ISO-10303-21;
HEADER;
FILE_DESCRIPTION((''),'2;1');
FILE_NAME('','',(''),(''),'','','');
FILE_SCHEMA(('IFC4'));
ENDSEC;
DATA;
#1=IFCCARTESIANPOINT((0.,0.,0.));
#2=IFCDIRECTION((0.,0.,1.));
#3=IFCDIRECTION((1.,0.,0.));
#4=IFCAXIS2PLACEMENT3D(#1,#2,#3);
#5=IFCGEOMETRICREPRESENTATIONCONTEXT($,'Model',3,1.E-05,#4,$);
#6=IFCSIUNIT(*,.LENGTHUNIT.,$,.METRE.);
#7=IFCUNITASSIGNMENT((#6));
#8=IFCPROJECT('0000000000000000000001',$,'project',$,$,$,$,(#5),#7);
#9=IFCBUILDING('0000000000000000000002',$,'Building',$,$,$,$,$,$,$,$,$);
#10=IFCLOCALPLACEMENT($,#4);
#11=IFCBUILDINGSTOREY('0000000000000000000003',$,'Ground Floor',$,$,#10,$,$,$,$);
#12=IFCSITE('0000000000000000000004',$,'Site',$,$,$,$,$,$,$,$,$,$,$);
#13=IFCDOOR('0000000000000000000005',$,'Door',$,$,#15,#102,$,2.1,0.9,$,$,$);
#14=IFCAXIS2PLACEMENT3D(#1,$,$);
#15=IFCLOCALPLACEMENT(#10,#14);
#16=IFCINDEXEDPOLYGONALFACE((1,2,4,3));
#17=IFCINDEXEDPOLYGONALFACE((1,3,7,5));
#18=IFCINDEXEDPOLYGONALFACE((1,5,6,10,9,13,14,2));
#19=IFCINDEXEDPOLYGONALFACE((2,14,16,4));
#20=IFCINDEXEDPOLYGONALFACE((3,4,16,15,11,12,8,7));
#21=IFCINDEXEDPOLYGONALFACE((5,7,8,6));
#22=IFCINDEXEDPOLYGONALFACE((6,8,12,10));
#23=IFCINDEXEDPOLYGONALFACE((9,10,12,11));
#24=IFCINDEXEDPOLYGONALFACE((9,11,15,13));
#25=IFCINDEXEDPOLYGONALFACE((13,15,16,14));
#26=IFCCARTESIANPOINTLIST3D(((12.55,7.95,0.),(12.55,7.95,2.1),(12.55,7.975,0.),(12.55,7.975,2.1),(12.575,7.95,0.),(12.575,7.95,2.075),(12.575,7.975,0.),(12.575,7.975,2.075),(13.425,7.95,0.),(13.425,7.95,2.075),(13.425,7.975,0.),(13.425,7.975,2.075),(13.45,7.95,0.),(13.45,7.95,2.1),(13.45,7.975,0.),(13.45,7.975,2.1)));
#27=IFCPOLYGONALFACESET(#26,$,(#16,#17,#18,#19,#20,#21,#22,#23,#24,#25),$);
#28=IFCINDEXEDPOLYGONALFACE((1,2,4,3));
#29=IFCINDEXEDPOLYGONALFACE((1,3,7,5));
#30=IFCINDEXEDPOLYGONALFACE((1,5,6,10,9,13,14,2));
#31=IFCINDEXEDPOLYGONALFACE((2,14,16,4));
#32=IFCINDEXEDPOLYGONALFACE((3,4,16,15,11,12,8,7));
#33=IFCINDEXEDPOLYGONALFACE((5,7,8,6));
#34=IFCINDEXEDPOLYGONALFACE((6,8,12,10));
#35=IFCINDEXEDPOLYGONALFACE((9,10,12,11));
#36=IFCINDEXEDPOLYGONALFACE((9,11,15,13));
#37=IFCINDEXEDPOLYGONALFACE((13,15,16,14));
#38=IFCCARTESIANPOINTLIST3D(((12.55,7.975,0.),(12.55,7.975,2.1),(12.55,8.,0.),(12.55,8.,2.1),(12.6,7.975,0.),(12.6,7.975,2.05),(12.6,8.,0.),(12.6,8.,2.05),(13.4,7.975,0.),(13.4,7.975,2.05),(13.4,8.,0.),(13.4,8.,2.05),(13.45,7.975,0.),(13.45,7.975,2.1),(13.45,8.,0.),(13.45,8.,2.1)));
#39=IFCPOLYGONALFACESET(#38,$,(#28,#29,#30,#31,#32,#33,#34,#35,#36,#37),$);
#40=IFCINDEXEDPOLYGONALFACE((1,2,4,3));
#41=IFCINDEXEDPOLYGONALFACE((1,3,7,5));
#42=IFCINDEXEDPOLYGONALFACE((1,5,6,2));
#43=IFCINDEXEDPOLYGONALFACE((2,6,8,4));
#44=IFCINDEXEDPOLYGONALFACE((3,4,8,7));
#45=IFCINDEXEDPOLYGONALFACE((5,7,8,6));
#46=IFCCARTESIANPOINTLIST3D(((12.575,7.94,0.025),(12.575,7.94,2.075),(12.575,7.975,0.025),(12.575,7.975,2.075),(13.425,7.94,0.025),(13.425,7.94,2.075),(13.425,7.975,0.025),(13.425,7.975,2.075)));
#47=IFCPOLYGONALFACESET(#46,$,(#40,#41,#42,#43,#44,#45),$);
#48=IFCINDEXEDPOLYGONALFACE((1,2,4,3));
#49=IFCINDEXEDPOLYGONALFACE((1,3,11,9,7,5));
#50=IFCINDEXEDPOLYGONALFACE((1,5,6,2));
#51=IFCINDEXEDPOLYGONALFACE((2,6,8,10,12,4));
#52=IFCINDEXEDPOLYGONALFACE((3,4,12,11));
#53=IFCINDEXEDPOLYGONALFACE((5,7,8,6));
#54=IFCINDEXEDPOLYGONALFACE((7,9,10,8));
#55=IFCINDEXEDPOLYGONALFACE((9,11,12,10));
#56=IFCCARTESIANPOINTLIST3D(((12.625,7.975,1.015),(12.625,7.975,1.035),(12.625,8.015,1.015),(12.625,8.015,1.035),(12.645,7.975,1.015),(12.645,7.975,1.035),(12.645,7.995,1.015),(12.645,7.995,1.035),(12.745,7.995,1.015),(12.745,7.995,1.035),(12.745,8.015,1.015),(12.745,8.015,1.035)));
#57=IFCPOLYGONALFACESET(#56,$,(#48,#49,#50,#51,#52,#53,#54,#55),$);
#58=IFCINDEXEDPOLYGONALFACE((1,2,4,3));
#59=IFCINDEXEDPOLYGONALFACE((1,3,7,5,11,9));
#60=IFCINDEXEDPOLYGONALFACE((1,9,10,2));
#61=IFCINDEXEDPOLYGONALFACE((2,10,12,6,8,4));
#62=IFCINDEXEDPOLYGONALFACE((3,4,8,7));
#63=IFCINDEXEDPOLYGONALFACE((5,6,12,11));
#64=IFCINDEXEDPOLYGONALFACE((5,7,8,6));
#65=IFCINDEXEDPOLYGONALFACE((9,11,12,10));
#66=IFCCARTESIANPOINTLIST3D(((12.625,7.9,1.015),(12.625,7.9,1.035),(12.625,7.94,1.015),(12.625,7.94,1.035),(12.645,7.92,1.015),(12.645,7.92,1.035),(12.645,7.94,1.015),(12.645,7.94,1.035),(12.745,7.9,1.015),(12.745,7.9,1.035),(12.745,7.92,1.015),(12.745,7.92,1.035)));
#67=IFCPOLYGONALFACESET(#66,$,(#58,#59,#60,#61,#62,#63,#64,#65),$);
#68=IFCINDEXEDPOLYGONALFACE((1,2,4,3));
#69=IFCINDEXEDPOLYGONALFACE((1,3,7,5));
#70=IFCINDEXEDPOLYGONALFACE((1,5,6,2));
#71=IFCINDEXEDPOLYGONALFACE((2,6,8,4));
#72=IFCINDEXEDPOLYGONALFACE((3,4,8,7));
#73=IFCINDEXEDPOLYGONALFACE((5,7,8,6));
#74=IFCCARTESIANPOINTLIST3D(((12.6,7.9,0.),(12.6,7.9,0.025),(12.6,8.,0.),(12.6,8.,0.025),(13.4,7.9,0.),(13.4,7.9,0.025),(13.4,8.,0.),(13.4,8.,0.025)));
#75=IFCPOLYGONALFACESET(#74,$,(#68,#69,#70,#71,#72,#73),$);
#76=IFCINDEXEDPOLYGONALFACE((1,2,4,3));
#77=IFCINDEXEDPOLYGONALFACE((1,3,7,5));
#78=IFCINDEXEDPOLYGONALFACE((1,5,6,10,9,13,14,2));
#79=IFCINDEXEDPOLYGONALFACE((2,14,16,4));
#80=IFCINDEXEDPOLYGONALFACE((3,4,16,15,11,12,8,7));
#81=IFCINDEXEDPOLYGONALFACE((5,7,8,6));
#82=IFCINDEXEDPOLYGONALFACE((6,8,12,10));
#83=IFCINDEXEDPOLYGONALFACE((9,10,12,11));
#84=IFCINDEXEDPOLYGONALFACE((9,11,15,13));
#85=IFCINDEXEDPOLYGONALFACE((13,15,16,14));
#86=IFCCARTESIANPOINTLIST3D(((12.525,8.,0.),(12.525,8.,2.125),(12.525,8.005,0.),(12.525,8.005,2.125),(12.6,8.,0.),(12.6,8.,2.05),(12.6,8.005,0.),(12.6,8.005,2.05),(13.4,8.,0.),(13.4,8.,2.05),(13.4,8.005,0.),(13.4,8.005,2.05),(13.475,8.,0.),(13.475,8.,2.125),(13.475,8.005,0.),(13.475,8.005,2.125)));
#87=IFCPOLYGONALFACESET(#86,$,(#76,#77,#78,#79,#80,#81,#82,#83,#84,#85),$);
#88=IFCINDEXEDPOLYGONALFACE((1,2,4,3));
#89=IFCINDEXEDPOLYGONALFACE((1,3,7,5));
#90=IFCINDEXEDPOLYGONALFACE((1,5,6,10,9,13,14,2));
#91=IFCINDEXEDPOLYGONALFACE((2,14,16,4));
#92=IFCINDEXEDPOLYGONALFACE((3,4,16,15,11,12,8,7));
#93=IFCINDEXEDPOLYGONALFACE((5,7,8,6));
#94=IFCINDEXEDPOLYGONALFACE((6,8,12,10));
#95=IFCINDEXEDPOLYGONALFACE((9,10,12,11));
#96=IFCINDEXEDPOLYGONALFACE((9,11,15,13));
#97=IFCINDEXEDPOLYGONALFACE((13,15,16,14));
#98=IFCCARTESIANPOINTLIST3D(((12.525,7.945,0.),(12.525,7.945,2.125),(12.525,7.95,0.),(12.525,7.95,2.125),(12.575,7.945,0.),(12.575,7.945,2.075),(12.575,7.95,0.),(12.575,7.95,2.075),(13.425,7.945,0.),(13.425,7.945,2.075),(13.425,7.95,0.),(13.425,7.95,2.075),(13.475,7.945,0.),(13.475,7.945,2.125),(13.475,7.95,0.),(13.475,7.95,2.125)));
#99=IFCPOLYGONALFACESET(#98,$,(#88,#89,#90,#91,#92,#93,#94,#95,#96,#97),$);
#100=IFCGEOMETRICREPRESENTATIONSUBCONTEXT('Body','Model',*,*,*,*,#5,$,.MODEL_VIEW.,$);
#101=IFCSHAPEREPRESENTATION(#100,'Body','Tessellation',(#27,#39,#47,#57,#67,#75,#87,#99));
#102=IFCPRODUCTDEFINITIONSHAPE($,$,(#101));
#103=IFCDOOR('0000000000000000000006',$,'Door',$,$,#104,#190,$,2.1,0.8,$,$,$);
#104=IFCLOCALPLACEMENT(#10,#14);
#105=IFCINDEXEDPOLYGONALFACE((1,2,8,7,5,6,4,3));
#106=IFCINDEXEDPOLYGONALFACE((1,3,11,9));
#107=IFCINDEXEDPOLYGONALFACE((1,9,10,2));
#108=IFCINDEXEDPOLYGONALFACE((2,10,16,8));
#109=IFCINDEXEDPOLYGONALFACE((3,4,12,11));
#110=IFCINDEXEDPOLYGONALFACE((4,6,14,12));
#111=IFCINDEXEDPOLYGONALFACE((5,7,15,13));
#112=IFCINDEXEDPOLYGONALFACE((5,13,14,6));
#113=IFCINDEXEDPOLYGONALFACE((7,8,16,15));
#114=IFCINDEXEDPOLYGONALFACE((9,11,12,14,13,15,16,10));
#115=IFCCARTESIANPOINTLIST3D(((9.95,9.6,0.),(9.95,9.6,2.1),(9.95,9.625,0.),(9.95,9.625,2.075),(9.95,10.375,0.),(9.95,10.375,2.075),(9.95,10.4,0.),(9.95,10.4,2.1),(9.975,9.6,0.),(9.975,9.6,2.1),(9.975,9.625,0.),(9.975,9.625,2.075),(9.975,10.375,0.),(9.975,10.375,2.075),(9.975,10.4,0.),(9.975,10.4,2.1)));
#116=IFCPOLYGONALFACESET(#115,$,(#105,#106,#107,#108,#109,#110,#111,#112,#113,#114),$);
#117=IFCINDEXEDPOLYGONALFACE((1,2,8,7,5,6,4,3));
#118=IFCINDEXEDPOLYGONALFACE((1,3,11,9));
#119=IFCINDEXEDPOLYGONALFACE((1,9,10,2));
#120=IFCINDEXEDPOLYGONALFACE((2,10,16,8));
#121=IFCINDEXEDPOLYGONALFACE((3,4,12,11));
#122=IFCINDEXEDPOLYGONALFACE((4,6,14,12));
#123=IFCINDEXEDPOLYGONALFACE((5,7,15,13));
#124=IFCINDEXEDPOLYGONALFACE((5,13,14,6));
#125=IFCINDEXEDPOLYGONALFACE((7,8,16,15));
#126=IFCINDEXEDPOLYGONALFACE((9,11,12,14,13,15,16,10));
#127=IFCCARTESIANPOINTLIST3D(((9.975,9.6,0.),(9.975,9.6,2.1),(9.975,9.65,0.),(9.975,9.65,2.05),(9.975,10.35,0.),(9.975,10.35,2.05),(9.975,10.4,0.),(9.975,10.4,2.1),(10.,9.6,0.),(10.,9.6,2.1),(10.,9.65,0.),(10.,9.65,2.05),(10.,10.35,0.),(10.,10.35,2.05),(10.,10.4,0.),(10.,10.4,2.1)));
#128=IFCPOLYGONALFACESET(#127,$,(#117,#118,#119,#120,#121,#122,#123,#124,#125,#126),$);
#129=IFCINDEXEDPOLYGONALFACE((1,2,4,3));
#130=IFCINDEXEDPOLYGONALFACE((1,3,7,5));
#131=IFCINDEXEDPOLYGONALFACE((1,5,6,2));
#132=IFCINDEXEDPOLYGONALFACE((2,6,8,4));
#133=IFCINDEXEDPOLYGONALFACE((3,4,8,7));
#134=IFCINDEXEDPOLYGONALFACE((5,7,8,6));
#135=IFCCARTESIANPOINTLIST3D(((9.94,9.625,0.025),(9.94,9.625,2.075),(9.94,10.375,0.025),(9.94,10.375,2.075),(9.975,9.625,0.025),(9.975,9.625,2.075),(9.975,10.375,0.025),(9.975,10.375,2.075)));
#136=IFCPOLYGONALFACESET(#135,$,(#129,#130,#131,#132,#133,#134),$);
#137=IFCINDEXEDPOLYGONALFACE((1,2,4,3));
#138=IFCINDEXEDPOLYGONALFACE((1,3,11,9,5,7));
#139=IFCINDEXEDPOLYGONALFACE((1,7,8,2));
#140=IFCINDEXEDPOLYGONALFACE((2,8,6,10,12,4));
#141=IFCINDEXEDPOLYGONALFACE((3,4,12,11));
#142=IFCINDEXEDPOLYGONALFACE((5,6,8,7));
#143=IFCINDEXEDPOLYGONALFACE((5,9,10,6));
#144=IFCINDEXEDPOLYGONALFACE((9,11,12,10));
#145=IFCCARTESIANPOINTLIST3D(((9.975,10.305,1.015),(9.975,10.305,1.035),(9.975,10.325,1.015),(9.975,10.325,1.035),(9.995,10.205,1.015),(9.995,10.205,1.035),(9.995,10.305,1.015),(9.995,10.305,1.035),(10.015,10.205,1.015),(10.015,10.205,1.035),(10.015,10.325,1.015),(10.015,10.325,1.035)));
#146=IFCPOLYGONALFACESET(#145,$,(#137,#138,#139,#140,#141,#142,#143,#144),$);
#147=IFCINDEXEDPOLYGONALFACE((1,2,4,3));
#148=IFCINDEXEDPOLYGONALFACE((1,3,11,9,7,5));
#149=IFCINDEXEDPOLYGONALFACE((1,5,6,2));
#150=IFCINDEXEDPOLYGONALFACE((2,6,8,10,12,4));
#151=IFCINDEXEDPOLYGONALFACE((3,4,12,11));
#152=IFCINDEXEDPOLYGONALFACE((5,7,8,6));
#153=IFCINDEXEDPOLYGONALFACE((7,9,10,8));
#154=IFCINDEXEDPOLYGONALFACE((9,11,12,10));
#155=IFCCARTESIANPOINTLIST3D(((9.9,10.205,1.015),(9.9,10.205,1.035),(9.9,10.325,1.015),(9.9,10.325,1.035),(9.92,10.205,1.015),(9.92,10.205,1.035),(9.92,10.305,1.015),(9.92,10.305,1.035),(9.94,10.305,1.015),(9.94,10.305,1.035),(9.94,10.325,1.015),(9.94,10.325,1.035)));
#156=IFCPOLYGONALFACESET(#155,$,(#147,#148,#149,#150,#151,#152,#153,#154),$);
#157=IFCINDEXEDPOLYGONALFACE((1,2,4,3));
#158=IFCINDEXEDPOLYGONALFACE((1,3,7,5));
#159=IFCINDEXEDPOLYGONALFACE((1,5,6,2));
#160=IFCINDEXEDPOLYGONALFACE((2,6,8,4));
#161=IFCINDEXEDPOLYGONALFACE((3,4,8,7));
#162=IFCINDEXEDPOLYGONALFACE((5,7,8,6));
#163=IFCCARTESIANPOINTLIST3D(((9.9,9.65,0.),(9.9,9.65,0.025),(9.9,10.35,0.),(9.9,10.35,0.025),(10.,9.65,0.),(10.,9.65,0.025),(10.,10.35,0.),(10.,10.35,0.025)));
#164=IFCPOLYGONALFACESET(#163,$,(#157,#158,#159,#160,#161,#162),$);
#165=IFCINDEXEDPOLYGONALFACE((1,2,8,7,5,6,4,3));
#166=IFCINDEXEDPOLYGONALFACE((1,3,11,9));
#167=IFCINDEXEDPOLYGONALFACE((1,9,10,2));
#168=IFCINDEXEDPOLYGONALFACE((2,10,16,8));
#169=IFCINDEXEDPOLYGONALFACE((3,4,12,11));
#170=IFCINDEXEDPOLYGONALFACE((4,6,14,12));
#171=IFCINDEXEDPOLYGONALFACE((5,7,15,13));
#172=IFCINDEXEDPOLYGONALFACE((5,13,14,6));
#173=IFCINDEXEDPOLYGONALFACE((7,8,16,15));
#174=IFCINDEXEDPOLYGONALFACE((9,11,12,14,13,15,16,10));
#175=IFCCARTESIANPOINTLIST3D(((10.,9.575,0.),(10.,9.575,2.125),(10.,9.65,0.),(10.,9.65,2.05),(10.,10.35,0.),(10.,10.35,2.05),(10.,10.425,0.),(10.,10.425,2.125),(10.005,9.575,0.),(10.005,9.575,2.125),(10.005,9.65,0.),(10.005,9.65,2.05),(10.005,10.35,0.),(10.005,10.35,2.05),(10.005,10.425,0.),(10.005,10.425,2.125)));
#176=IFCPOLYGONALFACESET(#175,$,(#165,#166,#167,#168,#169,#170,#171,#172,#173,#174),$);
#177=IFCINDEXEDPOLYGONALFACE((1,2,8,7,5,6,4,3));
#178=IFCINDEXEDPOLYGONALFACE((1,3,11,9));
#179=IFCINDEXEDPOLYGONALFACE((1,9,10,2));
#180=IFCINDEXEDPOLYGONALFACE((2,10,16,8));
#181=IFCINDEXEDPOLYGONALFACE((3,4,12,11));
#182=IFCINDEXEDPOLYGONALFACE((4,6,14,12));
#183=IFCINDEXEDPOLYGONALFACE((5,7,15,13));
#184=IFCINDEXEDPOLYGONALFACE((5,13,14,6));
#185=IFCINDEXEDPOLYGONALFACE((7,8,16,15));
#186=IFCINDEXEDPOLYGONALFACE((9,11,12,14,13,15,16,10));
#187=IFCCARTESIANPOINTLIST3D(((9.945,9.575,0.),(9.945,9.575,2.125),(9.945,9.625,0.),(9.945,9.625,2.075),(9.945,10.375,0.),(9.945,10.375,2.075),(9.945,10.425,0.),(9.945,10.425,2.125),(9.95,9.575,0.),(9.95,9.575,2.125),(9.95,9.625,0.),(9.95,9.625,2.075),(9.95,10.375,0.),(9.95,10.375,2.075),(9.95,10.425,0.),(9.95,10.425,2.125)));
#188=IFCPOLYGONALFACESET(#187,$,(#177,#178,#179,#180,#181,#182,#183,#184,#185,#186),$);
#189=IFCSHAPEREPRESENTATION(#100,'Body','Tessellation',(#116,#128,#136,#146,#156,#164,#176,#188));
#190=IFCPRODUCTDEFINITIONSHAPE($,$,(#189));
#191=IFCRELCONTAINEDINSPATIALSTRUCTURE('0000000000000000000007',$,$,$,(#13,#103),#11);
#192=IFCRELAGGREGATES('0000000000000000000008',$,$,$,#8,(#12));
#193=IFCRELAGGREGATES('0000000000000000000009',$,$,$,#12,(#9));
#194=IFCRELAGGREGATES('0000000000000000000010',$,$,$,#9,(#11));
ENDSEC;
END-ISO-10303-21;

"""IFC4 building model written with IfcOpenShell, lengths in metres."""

from ifc_helpers import new_model, si_unit, frame, origin_with_axes, place, context, subcontext, project, spatial, line, indexed_curve, outline, extrude, element, save


model = new_model("IFC4")

# Units and contexts
model_context = context("Model", 3, precision=1e-05, world=origin_with_axes())
body_context = subcontext(model_context, "Body", "Model", "MODEL_VIEW")
ifc_project = project(units=[si_unit("LENGTHUNIT", "METRE")], contexts=[model_context])

# Site, building, storey
site = spatial("IfcSite", under=ifc_project, Name="Site")
building = spatial("IfcBuilding", under=site, Name="Building")
storey_placement = place(None, origin_with_axes())
storey = spatial("IfcBuildingStorey", under=building, at=storey_placement, Name="Ground Floor")

# Doors
door_1_placement = place(storey_placement, frame((13.45, 8.0, 0.0), z_axis=(0.0, 0.0, 1.0), x_axis=(-1.0, 0.0, 0.0)))
element("IfcDoor", 1, at=door_1_placement, inside=storey, Name="Door", OverallHeight=2.1, OverallWidth=0.9, context=body_context, shape_type="SweptSolid", body=[
    extrude(outline(indexed_curve([(0.0, 0.0), (0.0, 2.1), (0.9, 2.1), (0.9, 0.0), (0.875, 0.0), (0.875, 2.075), (0.025, 2.075), (0.025, 0.0)], segments=[line(1, 2, 3, 4, 5, 6, 7, 8, 1)])), frame((0.0, 0.025, 0.0), z_axis=(0.0, -1.0, 0.0), x_axis=(1.0, 0.0, 0.0)), (0.0, 0.0, -1.0), 0.025),
    extrude(outline(indexed_curve([(0.0, 0.0), (0.0, 2.1), (0.9, 2.1), (0.9, 0.0), (0.85, 0.0), (0.85, 2.05), (0.05, 2.05), (0.05, 0.0)], segments=[line(1, 2, 3, 4, 5, 6, 7, 8, 1)])), frame((0.0, 0.0, 0.0), z_axis=(0.0, -1.0, 0.0), x_axis=(1.0, 0.0, 0.0)), (0.0, 0.0, -1.0), 0.025),
    extrude(outline(indexed_curve([(0.0, 0.0), (0.85, 0.0), (0.85, 0.035), (0.0, 0.035)], segments=[line(1, 2, 3, 4, 1)])), frame((0.025, 0.025, 0.025), z_axis=(0.0, 0.0, 1.0), x_axis=(1.0, 0.0, 0.0)), (0.0, 0.0, 1.0), 2.05),
    extrude(outline(indexed_curve([(0.0, 0.0), (0.0, -0.04), (-0.12, -0.04), (-0.12, -0.02), (-0.02, -0.02), (-0.02, 0.0)], segments=[line(1, 2, 3, 4, 5, 6, 1)])), frame((0.825, 0.025, 1.015), z_axis=(0.0, 0.0, 1.0), x_axis=(1.0, 0.0, 0.0)), (0.0, 0.0, 1.0), 0.02),
    extrude(outline(indexed_curve([(0.0, 0.0), (0.0, 0.04), (-0.12, 0.04), (-0.12, 0.02), (-0.02, 0.02), (-0.02, 0.0)], segments=[line(1, 2, 3, 4, 5, 6, 1)])), frame((0.825, 0.06, 1.015), z_axis=(0.0, 0.0, 1.0), x_axis=(1.0, 0.0, 0.0)), (0.0, 0.0, 1.0), 0.02),
    extrude(outline(indexed_curve([(0.0, 0.0), (0.8, 0.0), (0.8, 0.1), (0.0, 0.1)], segments=[line(1, 2, 3, 4, 1)])), frame((0.05, 0.0, 0.0), z_axis=(0.0, 0.0, 1.0), x_axis=(1.0, 0.0, 0.0)), (0.0, 0.0, 1.0), 0.025),
    extrude(outline(indexed_curve([(0.0, 0.0), (0.0, 2.125), (0.95, 2.125), (0.95, 0.0), (0.875, 0.0), (0.875, 2.05), (0.075, 2.05), (0.075, 0.0)], segments=[line(1, 2, 3, 4, 5, 6, 7, 8, 1)])), frame((-0.025, -0.005, 0.0), z_axis=(0.0, -1.0, 0.0), x_axis=(1.0, 0.0, 0.0)), (0.0, 0.0, -1.0), 0.005),
    extrude(outline(indexed_curve([(0.0, 0.0), (0.0, 2.125), (0.95, 2.125), (0.95, 0.0), (0.9, 0.0), (0.9, 2.075), (0.05, 2.075), (0.05, 0.0)], segments=[line(1, 2, 3, 4, 5, 6, 7, 8, 1)])), frame((-0.025, 0.05, 0.0), z_axis=(0.0, -1.0, 0.0), x_axis=(1.0, 0.0, 0.0)), (0.0, 0.0, -1.0), 0.005),
])
door_2_placement = place(storey_placement, frame((10.0, 9.6, 0.0), z_axis=(0.0, 0.0, 1.0), x_axis=(0.0, 1.0, 0.0)))
element("IfcDoor", 2, at=door_2_placement, inside=storey, Name="Door", OverallHeight=2.1, OverallWidth=0.8, context=body_context, shape_type="SweptSolid", body=[
    extrude(outline(indexed_curve([(0.0, 0.0), (0.0, 2.1), (0.8, 2.1), (0.8, 0.0), (0.775, 0.0), (0.775, 2.075), (0.025, 2.075), (0.025, 0.0)], segments=[line(1, 2, 3, 4, 5, 6, 7, 8, 1)])), frame((0.0, 0.025, 0.0), z_axis=(0.0, -1.0, 0.0), x_axis=(1.0, 0.0, 0.0)), (0.0, 0.0, -1.0), 0.025),
    extrude(outline(indexed_curve([(0.0, 0.0), (0.0, 2.1), (0.8, 2.1), (0.8, 0.0), (0.75, 0.0), (0.75, 2.05), (0.05, 2.05), (0.05, 0.0)], segments=[line(1, 2, 3, 4, 5, 6, 7, 8, 1)])), frame((0.0, 0.0, 0.0), z_axis=(0.0, -1.0, 0.0), x_axis=(1.0, 0.0, 0.0)), (0.0, 0.0, -1.0), 0.025),
    extrude(outline(indexed_curve([(0.0, 0.0), (0.75, 0.0), (0.75, 0.035), (0.0, 0.035)], segments=[line(1, 2, 3, 4, 1)])), frame((0.025, 0.025, 0.025), z_axis=(0.0, 0.0, 1.0), x_axis=(1.0, 0.0, 0.0)), (0.0, 0.0, 1.0), 2.05),
    extrude(outline(indexed_curve([(0.0, 0.0), (0.0, -0.04), (-0.12, -0.04), (-0.12, -0.02), (-0.02, -0.02), (-0.02, 0.0)], segments=[line(1, 2, 3, 4, 5, 6, 1)])), frame((0.725, 0.025, 1.015), z_axis=(0.0, 0.0, 1.0), x_axis=(1.0, 0.0, 0.0)), (0.0, 0.0, 1.0), 0.02),
    extrude(outline(indexed_curve([(0.0, 0.0), (0.0, 0.04), (-0.12, 0.04), (-0.12, 0.02), (-0.02, 0.02), (-0.02, 0.0)], segments=[line(1, 2, 3, 4, 5, 6, 1)])), frame((0.725, 0.06, 1.015), z_axis=(0.0, 0.0, 1.0), x_axis=(1.0, 0.0, 0.0)), (0.0, 0.0, 1.0), 0.02),
    extrude(outline(indexed_curve([(0.0, 0.0), (0.7, 0.0), (0.7, 0.1), (0.0, 0.1)], segments=[line(1, 2, 3, 4, 1)])), frame((0.05, 0.0, 0.0), z_axis=(0.0, 0.0, 1.0), x_axis=(1.0, 0.0, 0.0)), (0.0, 0.0, 1.0), 0.025),
    extrude(outline(indexed_curve([(0.0, 0.0), (0.0, 2.125), (0.85, 2.125), (0.85, 0.0), (0.775, 0.0), (0.775, 2.05), (0.075, 2.05), (0.075, 0.0)], segments=[line(1, 2, 3, 4, 5, 6, 7, 8, 1)])), frame((-0.025, -0.005, 0.0), z_axis=(0.0, -1.0, 0.0), x_axis=(1.0, 0.0, 0.0)), (0.0, 0.0, -1.0), 0.005),
    extrude(outline(indexed_curve([(0.0, 0.0), (0.0, 2.125), (0.85, 2.125), (0.85, 0.0), (0.8, 0.0), (0.8, 2.075), (0.05, 2.075), (0.05, 0.0)], segments=[line(1, 2, 3, 4, 5, 6, 7, 8, 1)])), frame((-0.025, 0.05, 0.0), z_axis=(0.0, -1.0, 0.0), x_axis=(1.0, 0.0, 0.0)), (0.0, 0.0, -1.0), 0.005),
])

save(model, "model.ifc")
